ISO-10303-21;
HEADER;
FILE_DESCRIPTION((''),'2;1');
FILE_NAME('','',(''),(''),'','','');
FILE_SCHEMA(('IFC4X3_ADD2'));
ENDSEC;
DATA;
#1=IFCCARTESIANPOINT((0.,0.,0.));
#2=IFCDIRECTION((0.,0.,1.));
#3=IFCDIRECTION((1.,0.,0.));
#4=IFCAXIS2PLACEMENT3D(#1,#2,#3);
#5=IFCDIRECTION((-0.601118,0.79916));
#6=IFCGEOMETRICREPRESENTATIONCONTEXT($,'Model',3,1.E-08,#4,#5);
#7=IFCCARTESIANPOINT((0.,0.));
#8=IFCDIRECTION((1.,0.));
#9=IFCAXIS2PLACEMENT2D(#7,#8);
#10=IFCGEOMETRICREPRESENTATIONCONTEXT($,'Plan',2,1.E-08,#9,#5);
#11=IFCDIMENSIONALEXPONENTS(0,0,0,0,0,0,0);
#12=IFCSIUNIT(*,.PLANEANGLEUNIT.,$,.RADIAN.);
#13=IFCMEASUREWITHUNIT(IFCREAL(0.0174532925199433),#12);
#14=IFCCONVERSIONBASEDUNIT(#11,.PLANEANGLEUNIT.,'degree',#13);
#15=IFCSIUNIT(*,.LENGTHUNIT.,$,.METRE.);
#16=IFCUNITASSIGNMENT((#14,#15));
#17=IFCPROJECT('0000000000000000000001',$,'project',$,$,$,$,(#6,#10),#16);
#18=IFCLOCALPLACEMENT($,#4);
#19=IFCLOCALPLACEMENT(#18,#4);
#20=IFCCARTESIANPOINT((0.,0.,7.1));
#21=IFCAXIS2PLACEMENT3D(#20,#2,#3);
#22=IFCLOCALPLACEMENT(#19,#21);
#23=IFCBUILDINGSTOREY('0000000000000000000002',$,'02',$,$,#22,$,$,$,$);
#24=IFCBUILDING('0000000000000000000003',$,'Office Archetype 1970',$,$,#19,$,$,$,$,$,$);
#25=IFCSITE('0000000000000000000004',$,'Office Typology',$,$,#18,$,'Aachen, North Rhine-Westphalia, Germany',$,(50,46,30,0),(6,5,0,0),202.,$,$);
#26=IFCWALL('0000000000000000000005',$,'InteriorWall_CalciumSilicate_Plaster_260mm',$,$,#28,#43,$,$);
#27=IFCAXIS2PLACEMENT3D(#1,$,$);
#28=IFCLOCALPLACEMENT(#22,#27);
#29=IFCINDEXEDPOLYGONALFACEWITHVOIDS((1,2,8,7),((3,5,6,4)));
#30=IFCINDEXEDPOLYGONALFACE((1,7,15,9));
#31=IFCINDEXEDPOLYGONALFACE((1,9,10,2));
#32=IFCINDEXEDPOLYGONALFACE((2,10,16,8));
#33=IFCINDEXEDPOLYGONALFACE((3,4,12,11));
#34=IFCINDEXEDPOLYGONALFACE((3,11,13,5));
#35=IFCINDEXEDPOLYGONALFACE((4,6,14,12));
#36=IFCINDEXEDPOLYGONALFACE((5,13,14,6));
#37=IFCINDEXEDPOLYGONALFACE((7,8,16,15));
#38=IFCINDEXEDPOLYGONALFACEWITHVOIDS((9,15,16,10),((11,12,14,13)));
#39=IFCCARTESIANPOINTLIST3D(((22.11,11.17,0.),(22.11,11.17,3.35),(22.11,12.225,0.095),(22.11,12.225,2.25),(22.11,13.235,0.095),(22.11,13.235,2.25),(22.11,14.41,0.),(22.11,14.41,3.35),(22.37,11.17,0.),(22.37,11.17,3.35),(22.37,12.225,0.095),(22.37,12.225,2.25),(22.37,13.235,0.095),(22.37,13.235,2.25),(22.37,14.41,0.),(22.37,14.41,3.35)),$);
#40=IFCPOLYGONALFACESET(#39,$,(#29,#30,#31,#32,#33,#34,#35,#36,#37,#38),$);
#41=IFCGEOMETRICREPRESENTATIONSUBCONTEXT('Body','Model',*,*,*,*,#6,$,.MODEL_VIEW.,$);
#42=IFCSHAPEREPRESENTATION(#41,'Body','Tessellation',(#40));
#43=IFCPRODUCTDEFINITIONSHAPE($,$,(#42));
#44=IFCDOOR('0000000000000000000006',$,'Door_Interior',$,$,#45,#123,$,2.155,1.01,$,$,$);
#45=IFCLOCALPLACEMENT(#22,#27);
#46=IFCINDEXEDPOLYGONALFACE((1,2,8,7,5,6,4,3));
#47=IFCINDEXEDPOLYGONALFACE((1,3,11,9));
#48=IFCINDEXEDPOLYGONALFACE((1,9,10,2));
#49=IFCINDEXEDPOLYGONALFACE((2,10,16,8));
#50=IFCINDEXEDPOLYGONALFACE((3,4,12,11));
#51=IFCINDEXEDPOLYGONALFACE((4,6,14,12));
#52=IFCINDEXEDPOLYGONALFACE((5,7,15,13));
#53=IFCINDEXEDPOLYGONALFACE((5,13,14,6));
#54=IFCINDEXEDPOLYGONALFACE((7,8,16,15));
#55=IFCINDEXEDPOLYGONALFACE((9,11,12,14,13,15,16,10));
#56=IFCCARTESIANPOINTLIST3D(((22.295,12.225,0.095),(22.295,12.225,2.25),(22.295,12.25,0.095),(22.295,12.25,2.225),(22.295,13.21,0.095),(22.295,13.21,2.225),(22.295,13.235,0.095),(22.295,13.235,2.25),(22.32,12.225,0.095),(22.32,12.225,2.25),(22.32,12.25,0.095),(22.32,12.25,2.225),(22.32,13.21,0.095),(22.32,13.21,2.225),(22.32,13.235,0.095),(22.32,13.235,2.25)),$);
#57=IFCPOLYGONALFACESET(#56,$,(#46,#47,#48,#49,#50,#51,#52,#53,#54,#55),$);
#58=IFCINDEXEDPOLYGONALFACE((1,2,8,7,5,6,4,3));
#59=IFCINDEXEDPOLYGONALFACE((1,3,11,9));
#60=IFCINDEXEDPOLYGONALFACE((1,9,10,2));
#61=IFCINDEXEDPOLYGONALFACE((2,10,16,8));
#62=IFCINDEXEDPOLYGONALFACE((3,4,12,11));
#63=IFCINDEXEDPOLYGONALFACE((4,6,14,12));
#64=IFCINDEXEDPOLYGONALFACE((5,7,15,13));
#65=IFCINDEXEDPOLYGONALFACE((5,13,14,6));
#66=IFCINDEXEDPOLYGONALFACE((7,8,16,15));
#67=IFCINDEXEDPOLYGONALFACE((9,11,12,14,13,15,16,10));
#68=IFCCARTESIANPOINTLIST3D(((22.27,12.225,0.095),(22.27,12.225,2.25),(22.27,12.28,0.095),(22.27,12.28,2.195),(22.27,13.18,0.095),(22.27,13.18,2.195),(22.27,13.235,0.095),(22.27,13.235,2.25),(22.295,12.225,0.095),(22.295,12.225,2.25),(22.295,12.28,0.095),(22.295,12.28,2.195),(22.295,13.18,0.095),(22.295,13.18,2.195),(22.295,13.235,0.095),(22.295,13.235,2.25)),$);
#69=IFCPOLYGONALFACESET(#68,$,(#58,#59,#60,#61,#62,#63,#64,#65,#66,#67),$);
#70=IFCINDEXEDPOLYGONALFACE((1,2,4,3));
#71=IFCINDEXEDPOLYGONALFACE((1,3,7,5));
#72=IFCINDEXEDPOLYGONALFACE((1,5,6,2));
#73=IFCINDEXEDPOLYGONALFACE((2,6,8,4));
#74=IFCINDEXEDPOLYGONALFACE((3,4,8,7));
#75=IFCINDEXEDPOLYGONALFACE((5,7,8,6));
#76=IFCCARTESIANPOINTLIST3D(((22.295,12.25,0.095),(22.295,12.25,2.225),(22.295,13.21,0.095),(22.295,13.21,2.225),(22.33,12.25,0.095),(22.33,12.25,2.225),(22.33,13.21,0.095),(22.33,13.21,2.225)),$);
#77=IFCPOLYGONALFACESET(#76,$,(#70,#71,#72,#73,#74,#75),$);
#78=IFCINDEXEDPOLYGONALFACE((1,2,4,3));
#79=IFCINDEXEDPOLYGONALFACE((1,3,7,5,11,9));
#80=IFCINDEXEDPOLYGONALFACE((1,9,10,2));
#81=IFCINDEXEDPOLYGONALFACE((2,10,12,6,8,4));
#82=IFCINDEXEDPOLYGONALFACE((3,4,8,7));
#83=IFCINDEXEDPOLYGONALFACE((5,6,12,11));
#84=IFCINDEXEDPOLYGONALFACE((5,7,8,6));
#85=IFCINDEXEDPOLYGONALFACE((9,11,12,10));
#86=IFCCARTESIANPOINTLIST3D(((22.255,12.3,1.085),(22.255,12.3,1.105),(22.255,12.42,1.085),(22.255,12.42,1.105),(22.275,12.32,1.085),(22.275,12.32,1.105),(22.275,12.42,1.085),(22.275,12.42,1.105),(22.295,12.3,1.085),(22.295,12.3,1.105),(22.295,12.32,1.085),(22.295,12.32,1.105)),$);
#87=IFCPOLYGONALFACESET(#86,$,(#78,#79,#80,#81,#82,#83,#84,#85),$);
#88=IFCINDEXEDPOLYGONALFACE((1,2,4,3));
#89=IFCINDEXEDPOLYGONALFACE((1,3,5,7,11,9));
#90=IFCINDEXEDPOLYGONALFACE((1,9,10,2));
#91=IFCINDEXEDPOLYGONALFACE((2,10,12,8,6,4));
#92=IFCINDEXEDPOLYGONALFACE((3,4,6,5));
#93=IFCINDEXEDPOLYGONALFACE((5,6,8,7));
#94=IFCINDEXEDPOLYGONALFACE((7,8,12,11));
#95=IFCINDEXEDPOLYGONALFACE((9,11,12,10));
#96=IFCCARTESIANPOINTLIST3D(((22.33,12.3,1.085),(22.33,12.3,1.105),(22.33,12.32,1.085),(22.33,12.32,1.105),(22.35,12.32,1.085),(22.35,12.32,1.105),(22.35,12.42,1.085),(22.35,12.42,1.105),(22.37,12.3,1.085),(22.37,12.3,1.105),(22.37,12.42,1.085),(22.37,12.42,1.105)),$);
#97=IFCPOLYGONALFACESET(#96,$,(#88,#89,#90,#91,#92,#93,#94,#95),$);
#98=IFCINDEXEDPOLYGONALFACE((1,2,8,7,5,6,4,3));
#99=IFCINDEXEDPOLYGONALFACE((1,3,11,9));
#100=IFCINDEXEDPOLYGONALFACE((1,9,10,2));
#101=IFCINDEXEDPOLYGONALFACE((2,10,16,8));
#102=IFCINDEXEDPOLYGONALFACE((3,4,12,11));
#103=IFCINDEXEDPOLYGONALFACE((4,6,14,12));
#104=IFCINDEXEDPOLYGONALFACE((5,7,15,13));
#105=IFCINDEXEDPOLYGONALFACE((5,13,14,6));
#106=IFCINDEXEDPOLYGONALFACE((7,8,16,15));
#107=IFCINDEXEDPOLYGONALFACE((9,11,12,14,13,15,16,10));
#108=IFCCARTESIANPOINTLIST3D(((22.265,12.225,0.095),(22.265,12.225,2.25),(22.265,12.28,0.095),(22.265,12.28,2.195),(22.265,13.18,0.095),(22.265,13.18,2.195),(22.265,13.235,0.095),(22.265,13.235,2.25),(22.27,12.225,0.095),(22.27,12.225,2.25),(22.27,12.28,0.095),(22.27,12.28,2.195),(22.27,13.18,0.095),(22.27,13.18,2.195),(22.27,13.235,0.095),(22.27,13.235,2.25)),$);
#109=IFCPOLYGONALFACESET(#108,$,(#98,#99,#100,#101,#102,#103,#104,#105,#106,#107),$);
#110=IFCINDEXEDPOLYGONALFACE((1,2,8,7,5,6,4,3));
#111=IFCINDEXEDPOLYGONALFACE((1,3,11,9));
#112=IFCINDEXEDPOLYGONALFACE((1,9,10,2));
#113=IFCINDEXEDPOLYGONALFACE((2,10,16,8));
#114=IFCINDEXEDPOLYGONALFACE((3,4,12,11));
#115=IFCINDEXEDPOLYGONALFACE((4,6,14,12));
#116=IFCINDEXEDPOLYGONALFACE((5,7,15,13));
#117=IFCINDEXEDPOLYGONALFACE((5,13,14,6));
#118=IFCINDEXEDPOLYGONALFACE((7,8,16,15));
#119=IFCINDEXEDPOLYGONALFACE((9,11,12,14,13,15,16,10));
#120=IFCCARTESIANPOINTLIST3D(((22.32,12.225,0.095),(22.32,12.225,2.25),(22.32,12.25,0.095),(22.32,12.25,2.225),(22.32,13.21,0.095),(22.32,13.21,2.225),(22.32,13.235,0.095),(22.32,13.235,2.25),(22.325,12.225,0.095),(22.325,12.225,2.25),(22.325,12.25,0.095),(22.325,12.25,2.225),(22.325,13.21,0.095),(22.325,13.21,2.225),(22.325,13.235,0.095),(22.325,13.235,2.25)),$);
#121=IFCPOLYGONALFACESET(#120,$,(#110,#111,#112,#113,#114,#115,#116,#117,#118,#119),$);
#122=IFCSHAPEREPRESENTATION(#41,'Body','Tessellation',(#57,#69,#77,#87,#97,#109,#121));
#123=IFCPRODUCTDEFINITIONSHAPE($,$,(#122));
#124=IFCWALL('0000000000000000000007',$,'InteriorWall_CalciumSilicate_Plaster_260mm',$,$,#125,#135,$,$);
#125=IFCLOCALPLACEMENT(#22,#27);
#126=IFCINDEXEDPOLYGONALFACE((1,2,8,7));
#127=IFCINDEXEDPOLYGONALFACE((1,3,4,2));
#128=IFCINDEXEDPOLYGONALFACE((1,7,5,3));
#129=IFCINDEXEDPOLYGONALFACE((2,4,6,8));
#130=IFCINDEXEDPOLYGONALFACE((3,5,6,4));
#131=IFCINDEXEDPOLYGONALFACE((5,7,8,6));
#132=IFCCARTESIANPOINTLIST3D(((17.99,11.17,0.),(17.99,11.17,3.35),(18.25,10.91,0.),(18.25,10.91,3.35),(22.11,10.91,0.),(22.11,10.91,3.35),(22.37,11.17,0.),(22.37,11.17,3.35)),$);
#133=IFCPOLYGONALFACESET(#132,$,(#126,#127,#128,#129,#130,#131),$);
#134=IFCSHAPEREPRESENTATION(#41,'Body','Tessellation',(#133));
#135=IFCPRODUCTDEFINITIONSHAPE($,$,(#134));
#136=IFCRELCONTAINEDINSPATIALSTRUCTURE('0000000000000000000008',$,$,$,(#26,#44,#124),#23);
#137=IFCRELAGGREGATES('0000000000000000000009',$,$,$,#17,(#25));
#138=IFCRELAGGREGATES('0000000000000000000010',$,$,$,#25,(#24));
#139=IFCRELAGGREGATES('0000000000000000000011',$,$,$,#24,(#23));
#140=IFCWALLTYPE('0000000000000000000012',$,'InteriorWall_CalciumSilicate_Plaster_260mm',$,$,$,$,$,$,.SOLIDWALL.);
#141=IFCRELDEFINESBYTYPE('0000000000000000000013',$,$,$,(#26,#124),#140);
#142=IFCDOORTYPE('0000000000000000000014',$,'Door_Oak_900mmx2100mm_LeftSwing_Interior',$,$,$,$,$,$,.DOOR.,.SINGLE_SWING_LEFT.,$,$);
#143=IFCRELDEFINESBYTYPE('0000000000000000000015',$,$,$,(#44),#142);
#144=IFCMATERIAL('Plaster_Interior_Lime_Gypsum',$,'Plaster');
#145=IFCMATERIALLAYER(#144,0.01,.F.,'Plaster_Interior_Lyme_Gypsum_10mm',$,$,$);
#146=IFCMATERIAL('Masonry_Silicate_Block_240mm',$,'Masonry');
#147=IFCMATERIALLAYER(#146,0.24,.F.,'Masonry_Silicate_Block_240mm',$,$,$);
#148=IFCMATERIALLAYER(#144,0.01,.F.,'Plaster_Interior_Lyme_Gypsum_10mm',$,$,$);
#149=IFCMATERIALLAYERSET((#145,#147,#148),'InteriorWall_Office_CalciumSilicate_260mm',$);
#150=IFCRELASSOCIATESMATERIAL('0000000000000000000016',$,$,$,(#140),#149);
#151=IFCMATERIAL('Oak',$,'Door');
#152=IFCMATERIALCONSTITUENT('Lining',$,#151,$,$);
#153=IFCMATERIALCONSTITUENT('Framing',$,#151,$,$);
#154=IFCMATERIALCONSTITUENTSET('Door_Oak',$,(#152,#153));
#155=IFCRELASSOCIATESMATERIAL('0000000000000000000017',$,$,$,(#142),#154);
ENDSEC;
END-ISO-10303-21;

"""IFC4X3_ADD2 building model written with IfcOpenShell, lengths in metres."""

from ifc_helpers import new_model, entity, si_unit, converted_unit, direction, frame, origin_with_axes, origin_2d_with_axis, place, context, subcontext, project, spatial, line, indexed_curve, outline, extrude, source, transform, mapped, material, layer, layer_set, constituent, constituent_set, type_object, type_shapes, element, fill, save


model = new_model("IFC4X3_ADD2")

# Units and contexts
model_context = context("Model", 3, precision=1e-08, world=origin_with_axes(), true_north=direction((-0.601118, 0.79916)))
plan_context = context("Plan", 2, precision=1e-08, world=origin_2d_with_axis(), true_north=direction((-0.601118, 0.79916)))
body_context = subcontext(model_context, "Body", "Model", "MODEL_VIEW")
ifc_project = project(units=[converted_unit("PLANEANGLEUNIT", "degree", entity("IfcReal", 0.0174532925199433), si_unit("PLANEANGLEUNIT", "RADIAN"), dimensions=[0, 0, 0, 0, 0, 0, 0]), si_unit("LENGTHUNIT", "METRE")], contexts=[model_context, plan_context])

# Site, building, storey
site_placement = place(None, origin_with_axes())
site = spatial("IfcSite", under=ifc_project, at=site_placement, Name="Office Typology", LongName="Aachen, North Rhine-Westphalia, Germany", RefLatitude=(50, 46, 30, 0), RefLongitude=(6, 5, 0, 0), RefElevation=202.0)
building_placement = place(site_placement, origin_with_axes())
building = spatial("IfcBuilding", under=site, at=building_placement, Name="Office Archetype 1970")
storey_placement = place(building_placement, frame((0.0, 0.0, 7.1), z_axis=(0.0, 0.0, 1.0), x_axis=(1.0, 0.0, 0.0)))
storey = spatial("IfcBuildingStorey", under=building, at=storey_placement, Name="02")

# Wall, opening, door
ifc_material_1 = material(Name="Plaster_Interior_Lime_Gypsum", Category="Plaster")
ifc_layer_1 = layer(ifc_material_1, 0.01, ventilated=False, Name="Plaster_Interior_Lyme_Gypsum_10mm")
ifc_material_2 = material(Name="Masonry_Silicate_Block_240mm", Category="Masonry")
ifc_layer_2 = layer(ifc_material_2, 0.24, ventilated=False, Name="Masonry_Silicate_Block_240mm")
ifc_layer_3 = layer(ifc_material_1, 0.01, ventilated=False, Name="Plaster_Interior_Lyme_Gypsum_10mm")
ifc_layer_set = layer_set([ifc_layer_1, ifc_layer_2, ifc_layer_3], Name="InteriorWall_Office_CalciumSilicate_260mm")
wall_type = type_object("IfcWallType", Name="InteriorWall_CalciumSilicate_Plaster_260mm", PredefinedType="SOLIDWALL", material=ifc_layer_set)
wall_1_placement = place(storey_placement, frame((22.37, 11.17, 0.0), z_axis=(0.0, 0.0, 1.0), x_axis=(0.0, 1.0, 0.0)))
wall_1 = element("IfcWall", 1, at=wall_1_placement, inside=storey, type_object=wall_type, Name="InteriorWall_CalciumSilicate_Plaster_260mm", context=body_context, shape_type="SweptSolid", body=[
    extrude(outline(indexed_curve([(0.0, 0.0), (0.0, 0.26), (3.24, 0.26), (3.24, 0.0)], segments=[line(1, 2, 3, 4, 1)])), origin_with_axes(), (0.0, 0.0, 1.0), 3.35),
])
shared_shape_1 = source(origin_with_axes(), body_context, "Body", "SweptSolid", [
    extrude(outline(indexed_curve([(0.0, 0.0), (1.01, 0.0), (1.01, 2.155), (0.0, 2.155), (0.0, 0.0)])), frame((0.0, -0.16, 0.0), z_axis=(0.0, -1.0, 0.0), x_axis=(1.0, 0.0, 0.0)), (0.0, 0.0, -1.0), 0.261),
])
opening_placement = place(wall_1_placement, frame((2.065, 0.1, 0.095), z_axis=(0.0, 0.0, 1.0), x_axis=(-1.0, 0.0, 0.0)))
opening = element("IfcOpeningElement", 2, at=opening_placement, cuts=wall_1, PredefinedType="OPENING", context=body_context, shape_type="MappedRepresentation", body=[
    mapped(shared_shape_1, transform((0.0, 0.0, 0.0), x_axis=(1.0, 0.0, 0.0), y_axis=(0.0, 1.0, 0.0), z_axis=(0.0, 0.0, 1.0), scale=1.0)),
])
ifc_material_3 = material(Name="Oak", Category="Door")
ifc_constituent_1 = constituent(ifc_material_3, Name="Lining")
ifc_constituent_2 = constituent(ifc_material_3, Name="Framing")
ifc_constituent_set = constituent_set(constituents=[ifc_constituent_1, ifc_constituent_2], Name="Door_Oak")
door_type = type_object("IfcDoorType", Name="Door_Oak_900mmx2100mm_LeftSwing_Interior", OperationType="SINGLE_SWING_LEFT", PredefinedType="DOOR", material=ifc_constituent_set)
shared_shape_2 = source(origin_with_axes(), body_context, "Body", "SweptSolid", [
    extrude(outline(indexed_curve([(0.0, 0.0), (0.0, 2.155), (1.01, 2.155), (1.01, 0.0), (0.985, 0.0), (0.985, 2.13), (0.025, 2.13), (0.025, 0.0)], segments=[line(1, 2, 3, 4, 5, 6, 7, 8, 1)])), frame((0.0, 0.025, 0.0), z_axis=(0.0, -1.0, 0.0), x_axis=(1.0, 0.0, 0.0)), (0.0, 0.0, -1.0), 0.025),
    extrude(outline(indexed_curve([(0.0, 0.0), (0.0, 2.155), (1.01, 2.155), (1.01, 0.0), (0.955, 0.0), (0.955, 2.1), (0.055, 2.1), (0.055, 0.0)], segments=[line(1, 2, 3, 4, 5, 6, 7, 8, 1)])), frame((0.0, 0.0, 0.0), z_axis=(0.0, -1.0, 0.0), x_axis=(1.0, 0.0, 0.0)), (0.0, 0.0, -1.0), 0.025),
    extrude(outline(indexed_curve([(0.0, 0.0), (0.96, 0.0), (0.96, 0.035), (0.0, 0.035)], segments=[line(1, 2, 3, 4, 1)])), frame((0.025, 0.025, 0.0), z_axis=(0.0, 0.0, 1.0), x_axis=(1.0, 0.0, 0.0)), (0.0, 0.0, 1.0), 2.13),
    extrude(outline(indexed_curve([(0.0, 0.0), (0.0, -0.04), (-0.12, -0.04), (-0.12, -0.02), (-0.02, -0.02), (-0.02, 0.0)], segments=[line(1, 2, 3, 4, 5, 6, 1)])), frame((0.935, 0.025, 0.99), z_axis=(0.0, 0.0, 1.0), x_axis=(1.0, 0.0, 0.0)), (0.0, 0.0, 1.0), 0.02),
    extrude(outline(indexed_curve([(0.0, 0.0), (0.0, 0.04), (-0.12, 0.04), (-0.12, 0.02), (-0.02, 0.02), (-0.02, 0.0)], segments=[line(1, 2, 3, 4, 5, 6, 1)])), frame((0.935, 0.06, 0.99), z_axis=(0.0, 0.0, 1.0), x_axis=(1.0, 0.0, 0.0)), (0.0, 0.0, 1.0), 0.02),
    extrude(outline(indexed_curve([(0.0, 0.0), (0.0, 2.155), (1.01, 2.155), (1.01, 0.0), (0.955, 0.0), (0.955, 2.1), (0.055, 2.1), (0.055, 0.0)], segments=[line(1, 2, 3, 4, 5, 6, 7, 8, 1)])), frame((0.0, -0.005, 0.0), z_axis=(0.0, -1.0, 0.0), x_axis=(1.0, 0.0, 0.0)), (0.0, 0.0, -1.0), 0.005),
    extrude(outline(indexed_curve([(0.0, 0.0), (0.0, 2.155), (1.01, 2.155), (1.01, 0.0), (0.985, 0.0), (0.985, 2.13), (0.025, 2.13), (0.025, 0.0)], segments=[line(1, 2, 3, 4, 5, 6, 7, 8, 1)])), frame((0.0, 0.05, 0.0), z_axis=(0.0, -1.0, 0.0), x_axis=(1.0, 0.0, 0.0)), (0.0, 0.0, -1.0), 0.005),
])
type_shapes(door_type, [shared_shape_2])
door_placement = place(opening_placement, origin_with_axes())
door = element("IfcDoor", 3, at=door_placement, inside=storey, type_object=door_type, Name="Door_Interior", OverallHeight=2.155, OverallWidth=1.01, context=body_context, shape_type="MappedRepresentation", body=[
    mapped(shared_shape_2, transform((0.0, 0.0, 0.0), x_axis=(1.0, 0.0, 0.0), y_axis=(0.0, 1.0, 0.0), z_axis=(0.0, 0.0, 1.0), scale=1.0)),
])
fill(opening, door)

# Wall
wall_2_placement = place(storey_placement, frame((22.37, 11.17, 0.0), z_axis=(0.0, 0.0, 1.0), x_axis=(-1.0, 0.0, 0.0)))
element("IfcWall", 4, at=wall_2_placement, inside=storey, type_object=wall_type, Name="InteriorWall_CalciumSilicate_Plaster_260mm", context=body_context, shape_type="SweptSolid", body=[
    extrude(outline(indexed_curve([(0.0, 0.0), (0.26, 0.26), (4.12, 0.26), (4.38, 0.0)], segments=[line(1, 2, 3, 4, 1)])), origin_with_axes(), (0.0, 0.0, 1.0), 3.35),
])

save(model, "model.ifc")
